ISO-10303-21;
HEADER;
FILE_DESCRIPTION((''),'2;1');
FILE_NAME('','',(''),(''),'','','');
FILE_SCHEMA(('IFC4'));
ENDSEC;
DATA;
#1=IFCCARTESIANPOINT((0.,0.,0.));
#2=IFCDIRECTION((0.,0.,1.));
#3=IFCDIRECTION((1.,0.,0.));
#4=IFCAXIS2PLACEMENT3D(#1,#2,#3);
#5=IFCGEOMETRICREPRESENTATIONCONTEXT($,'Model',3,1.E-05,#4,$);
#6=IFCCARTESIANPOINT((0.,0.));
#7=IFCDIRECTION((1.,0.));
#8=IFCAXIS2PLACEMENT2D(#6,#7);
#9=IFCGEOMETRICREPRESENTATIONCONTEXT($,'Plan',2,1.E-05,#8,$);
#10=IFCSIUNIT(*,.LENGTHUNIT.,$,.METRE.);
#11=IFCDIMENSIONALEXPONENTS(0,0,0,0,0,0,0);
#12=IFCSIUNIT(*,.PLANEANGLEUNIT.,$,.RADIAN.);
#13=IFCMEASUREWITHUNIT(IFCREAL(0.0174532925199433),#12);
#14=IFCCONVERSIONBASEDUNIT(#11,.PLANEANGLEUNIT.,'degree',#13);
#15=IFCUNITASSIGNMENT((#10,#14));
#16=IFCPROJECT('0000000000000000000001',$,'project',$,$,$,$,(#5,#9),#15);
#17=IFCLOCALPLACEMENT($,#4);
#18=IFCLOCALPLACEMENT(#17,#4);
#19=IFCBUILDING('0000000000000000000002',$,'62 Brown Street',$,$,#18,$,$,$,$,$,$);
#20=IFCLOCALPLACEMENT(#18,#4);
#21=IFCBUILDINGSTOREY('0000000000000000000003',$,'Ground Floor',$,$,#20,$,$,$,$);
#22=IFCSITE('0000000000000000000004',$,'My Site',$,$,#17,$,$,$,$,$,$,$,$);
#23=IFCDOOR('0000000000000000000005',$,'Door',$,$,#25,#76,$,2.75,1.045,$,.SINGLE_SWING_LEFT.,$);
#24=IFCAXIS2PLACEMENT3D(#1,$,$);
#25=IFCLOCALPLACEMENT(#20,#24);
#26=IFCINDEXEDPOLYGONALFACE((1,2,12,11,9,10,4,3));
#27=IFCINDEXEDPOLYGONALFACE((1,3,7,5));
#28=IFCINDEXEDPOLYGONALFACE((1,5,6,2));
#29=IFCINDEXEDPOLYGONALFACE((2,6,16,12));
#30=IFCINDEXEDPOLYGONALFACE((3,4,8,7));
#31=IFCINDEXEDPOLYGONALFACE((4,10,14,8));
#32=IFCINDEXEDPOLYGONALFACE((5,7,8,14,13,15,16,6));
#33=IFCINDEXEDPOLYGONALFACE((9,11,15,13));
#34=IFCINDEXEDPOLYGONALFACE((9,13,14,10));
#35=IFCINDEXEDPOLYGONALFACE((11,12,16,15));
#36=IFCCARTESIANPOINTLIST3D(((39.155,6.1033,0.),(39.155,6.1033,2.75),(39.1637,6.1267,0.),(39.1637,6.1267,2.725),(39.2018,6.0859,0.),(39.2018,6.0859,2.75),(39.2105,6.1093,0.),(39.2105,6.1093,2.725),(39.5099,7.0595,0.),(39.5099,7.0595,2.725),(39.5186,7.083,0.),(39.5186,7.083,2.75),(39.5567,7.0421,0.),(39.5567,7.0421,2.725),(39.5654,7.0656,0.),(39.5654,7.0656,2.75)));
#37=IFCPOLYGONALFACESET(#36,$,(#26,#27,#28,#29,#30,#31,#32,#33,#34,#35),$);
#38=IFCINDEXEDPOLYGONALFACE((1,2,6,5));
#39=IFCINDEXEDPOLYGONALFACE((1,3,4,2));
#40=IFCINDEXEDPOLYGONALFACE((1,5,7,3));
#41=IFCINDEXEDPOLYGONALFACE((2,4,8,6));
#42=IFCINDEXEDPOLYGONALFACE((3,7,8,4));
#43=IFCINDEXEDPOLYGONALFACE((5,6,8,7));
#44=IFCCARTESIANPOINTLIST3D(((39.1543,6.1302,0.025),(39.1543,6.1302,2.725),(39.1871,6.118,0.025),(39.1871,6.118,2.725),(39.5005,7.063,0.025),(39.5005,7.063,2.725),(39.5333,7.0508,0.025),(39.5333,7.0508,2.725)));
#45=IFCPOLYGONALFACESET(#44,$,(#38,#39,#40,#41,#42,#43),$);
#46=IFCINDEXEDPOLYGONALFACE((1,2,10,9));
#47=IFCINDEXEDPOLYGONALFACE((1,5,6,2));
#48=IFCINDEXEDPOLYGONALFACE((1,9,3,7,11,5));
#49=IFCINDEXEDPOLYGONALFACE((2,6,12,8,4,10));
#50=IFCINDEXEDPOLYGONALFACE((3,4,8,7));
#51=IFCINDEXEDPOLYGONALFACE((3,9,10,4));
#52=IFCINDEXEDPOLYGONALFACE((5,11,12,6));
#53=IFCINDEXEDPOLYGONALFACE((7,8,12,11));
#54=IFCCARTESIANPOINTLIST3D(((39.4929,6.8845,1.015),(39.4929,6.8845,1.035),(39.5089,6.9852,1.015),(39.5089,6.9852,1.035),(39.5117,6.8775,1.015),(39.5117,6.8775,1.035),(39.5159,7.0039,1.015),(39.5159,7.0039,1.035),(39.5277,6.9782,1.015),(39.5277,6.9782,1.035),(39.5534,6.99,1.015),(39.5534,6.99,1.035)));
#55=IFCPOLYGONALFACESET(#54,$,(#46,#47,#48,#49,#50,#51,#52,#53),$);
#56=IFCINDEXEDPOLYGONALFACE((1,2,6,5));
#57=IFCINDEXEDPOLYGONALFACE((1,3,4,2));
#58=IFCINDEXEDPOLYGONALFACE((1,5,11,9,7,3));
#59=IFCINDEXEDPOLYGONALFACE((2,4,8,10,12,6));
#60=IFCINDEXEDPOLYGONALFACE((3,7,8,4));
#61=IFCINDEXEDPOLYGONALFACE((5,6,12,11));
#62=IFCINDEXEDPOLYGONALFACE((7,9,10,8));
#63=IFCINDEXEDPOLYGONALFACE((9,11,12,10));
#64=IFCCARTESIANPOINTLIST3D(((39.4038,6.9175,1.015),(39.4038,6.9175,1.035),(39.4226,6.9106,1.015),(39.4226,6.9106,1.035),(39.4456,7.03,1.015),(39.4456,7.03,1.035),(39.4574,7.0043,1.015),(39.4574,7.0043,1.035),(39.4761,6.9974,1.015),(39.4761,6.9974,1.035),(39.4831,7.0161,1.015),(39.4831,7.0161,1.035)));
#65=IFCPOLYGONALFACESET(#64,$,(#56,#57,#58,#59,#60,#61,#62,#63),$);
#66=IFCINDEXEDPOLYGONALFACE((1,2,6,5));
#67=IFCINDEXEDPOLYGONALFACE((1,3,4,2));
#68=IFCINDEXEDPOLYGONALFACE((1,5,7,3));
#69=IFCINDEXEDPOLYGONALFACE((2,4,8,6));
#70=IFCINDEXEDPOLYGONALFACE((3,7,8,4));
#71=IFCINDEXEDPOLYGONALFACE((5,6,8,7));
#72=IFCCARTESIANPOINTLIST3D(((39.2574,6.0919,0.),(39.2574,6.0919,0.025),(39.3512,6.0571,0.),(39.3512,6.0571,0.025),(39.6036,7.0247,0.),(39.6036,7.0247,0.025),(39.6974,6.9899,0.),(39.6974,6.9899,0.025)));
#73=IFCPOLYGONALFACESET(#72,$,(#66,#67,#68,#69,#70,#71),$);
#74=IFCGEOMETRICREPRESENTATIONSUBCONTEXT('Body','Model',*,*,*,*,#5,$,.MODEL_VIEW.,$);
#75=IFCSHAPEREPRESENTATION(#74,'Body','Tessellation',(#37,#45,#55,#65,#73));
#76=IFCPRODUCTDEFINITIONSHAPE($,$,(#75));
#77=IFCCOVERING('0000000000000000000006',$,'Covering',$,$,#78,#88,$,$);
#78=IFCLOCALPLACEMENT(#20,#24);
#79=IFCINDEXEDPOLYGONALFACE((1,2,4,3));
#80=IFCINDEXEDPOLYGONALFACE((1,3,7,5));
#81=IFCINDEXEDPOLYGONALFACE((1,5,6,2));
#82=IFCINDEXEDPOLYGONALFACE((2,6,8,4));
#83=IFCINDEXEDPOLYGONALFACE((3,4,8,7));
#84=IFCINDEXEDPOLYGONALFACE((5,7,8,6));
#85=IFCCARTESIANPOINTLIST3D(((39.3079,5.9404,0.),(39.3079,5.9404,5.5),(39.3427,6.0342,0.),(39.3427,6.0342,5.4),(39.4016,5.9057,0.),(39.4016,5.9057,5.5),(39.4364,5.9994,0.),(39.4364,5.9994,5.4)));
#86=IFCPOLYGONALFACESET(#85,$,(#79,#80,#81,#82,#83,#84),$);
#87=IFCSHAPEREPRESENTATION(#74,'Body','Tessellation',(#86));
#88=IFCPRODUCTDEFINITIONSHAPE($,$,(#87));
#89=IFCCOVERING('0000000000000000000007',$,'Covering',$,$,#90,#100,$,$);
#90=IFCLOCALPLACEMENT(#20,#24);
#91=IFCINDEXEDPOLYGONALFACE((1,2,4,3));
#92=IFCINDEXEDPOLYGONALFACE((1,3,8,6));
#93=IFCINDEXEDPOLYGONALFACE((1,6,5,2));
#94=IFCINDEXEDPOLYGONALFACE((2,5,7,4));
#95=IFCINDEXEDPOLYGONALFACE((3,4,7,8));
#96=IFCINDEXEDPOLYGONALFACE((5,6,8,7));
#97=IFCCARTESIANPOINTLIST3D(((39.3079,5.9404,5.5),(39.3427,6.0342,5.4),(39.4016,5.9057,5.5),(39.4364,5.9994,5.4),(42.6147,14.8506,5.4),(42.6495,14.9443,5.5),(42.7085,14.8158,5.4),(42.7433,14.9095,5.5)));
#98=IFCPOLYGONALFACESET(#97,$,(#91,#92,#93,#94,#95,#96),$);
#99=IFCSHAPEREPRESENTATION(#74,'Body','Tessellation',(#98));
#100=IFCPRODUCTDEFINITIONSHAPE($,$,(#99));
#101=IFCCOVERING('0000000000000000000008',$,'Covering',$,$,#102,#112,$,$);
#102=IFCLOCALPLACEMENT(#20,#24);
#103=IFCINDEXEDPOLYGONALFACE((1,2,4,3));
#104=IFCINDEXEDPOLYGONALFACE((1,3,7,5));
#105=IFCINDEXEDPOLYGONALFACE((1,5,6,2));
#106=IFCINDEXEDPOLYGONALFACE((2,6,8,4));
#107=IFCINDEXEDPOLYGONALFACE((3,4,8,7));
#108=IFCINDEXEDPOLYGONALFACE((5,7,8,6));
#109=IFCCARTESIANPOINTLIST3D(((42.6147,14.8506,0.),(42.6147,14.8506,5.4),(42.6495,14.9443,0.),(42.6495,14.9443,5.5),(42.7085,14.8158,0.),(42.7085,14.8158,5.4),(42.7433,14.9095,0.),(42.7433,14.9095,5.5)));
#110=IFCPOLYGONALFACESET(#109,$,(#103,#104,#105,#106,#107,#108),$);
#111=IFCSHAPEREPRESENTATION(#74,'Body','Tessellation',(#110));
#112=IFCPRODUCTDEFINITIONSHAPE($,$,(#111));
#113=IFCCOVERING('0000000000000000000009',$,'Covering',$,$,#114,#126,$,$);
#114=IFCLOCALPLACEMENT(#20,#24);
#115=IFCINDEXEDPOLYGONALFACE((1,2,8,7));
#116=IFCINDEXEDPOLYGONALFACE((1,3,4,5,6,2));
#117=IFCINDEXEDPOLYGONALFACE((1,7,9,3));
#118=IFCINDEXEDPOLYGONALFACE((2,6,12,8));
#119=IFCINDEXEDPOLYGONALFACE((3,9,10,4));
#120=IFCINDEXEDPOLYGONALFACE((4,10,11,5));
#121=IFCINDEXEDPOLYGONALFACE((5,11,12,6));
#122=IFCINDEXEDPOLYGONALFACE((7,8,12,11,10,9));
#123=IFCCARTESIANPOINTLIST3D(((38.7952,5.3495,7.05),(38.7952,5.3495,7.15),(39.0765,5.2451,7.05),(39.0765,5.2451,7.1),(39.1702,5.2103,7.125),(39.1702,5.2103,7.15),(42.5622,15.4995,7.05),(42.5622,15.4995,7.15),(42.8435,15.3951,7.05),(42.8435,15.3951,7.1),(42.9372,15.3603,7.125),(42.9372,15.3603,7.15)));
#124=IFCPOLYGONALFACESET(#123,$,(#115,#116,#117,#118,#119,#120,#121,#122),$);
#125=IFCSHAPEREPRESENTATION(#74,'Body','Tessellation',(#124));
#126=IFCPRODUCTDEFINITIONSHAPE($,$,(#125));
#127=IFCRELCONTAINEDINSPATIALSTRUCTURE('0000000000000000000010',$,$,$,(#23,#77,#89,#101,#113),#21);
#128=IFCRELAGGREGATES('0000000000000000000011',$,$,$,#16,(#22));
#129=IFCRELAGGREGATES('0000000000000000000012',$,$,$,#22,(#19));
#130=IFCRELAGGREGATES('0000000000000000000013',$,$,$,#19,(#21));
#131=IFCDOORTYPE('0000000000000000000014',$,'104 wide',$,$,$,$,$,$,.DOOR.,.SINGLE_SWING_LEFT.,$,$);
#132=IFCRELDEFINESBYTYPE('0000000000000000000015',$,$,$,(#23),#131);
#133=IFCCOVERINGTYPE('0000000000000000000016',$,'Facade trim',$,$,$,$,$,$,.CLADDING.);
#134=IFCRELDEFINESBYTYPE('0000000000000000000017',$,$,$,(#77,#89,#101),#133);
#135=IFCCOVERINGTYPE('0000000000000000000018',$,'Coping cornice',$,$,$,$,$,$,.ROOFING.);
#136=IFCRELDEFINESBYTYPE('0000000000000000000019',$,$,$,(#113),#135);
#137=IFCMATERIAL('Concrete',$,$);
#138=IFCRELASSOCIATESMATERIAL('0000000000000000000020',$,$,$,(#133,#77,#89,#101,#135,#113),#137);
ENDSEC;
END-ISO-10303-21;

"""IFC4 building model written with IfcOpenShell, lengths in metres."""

from ifc_helpers import new_model, entity, si_unit, converted_unit, frame, origin_with_axes, origin_2d_with_axis, place, context, subcontext, project, spatial, line, indexed_curve, rectangle, outline, extrude, clip, halfspace, shape, source, transform, mapped, material, material_profile, profile_set, profile_usage, type_object, type_shapes, element, save


model = new_model("IFC4")

# Units and contexts
model_context = context("Model", 3, precision=1e-05, world=origin_with_axes())
plan_context = context("Plan", 2, precision=1e-05, world=origin_2d_with_axis())
body_context_1 = subcontext(model_context, "Body", "Model", "MODEL_VIEW")
body_context_2 = subcontext(plan_context, "Body", "Plan", "PLAN_VIEW")
ifc_project = project(units=[si_unit("LENGTHUNIT", "METRE"), converted_unit("PLANEANGLEUNIT", "degree", entity("IfcReal", 0.0174532925199433), si_unit("PLANEANGLEUNIT", "RADIAN"), dimensions=[0, 0, 0, 0, 0, 0, 0])], contexts=[model_context, plan_context])

# Site, building, storey
site_placement = place(None, origin_with_axes())
site = spatial("IfcSite", under=ifc_project, at=site_placement, Name="My Site")
building_placement = place(site_placement, origin_with_axes())
building = spatial("IfcBuilding", under=site, at=building_placement, Name="62 Brown Street")
storey_placement = place(building_placement, origin_with_axes())
storey = spatial("IfcBuildingStorey", under=building, at=storey_placement, Name="Ground Floor")

# Shared definitions
ifc_material_1 = material(Name="Concrete")

# Shared definitions
placement_1 = place(storey_placement, frame((39.024, 5.1755, 0.0), z_axis=(0.0, 0.0, 1.0), x_axis=(0.347944, 0.937515, 0.0)))

# Door
door_type_1 = type_object("IfcDoorType", Name="104 wide", OperationType="SINGLE_SWING_LEFT", PredefinedType="DOOR")
shared_shape_1 = source(origin_with_axes(), body_context_1, "Body", "SweptSolid", [
    extrude(outline(indexed_curve([(0.0, 0.0), (0.0, 2.75), (1.045, 2.75), (1.045, 0.0), (1.02, 0.0), (1.02, 2.725), (0.025, 2.725), (0.025, 0.0)], segments=[line(1, 2, 3, 4, 5, 6, 7, 8, 1)])), frame((0.0, 0.15, 0.0), z_axis=(0.0, -1.0, 0.0), x_axis=(1.0, 0.0, 0.0)), (0.0, 0.0, -1.0), 0.05),
    extrude(outline(indexed_curve([(0.0, 0.0), (0.995, 0.0), (0.995, 0.035), (0.0, 0.035)], segments=[line(1, 2, 3, 4, 1)])), frame((0.025, 0.175, 0.025), z_axis=(0.0, 0.0, 1.0), x_axis=(1.0, 0.0, 0.0)), (0.0, 0.0, 1.0), 2.7),
    extrude(outline(indexed_curve([(0.0, 0.0), (0.0, -0.04), (-0.12, -0.04), (-0.12, -0.02), (-0.02, -0.02), (-0.02, 0.0)], segments=[line(1, 2, 3, 4, 5, 6, 1)])), frame((0.97, 0.175, 1.015), z_axis=(0.0, 0.0, 1.0), x_axis=(1.0, 0.0, 0.0)), (0.0, 0.0, 1.0), 0.02),
    extrude(outline(indexed_curve([(0.0, 0.0), (0.0, 0.04), (-0.12, 0.04), (-0.12, 0.02), (-0.02, 0.02), (-0.02, 0.0)], segments=[line(1, 2, 3, 4, 5, 6, 1)])), frame((0.97, 0.21, 1.015), z_axis=(0.0, 0.0, 1.0), x_axis=(1.0, 0.0, 0.0)), (0.0, 0.0, 1.0), 0.02),
    extrude(outline(indexed_curve([(0.0, 0.0), (0.995, 0.0), (0.995, 0.1), (0.0, 0.1)], segments=[line(1, 2, 3, 4, 1)])), frame((0.025, 0.0, 0.0), z_axis=(0.0, 0.0, 1.0), x_axis=(1.0, 0.0, 0.0)), (0.0, 0.0, 1.0), 0.025),
])
shared_shape_2 = source(origin_with_axes(), body_context_2, "Body", "Curve2D", [
    entity("IfcIndexedPolyCurve", entity("IfcCartesianPointList2D", [[0.0, 0.15], [0.025, 0.15], [0.025, 0.2], [0.0, 0.2]]), [entity("IfcLineIndex", [1, 2, 3, 4, 1])]),
    entity("IfcIndexedPolyCurve", entity("IfcCartesianPointList2D", [[1.045, 0.15], [1.02, 0.15], [1.02, 0.2], [1.045, 0.2]]), [entity("IfcLineIndex", [1, 2, 3, 4, 1])]),
    entity("IfcTrimmedCurve", entity("IfcEllipse", entity("IfcAxis2Placement2D", entity("IfcCartesianPoint", [0.06, 0.2]), entity("IfcDirection", [1.0, 0.0])), 0.96, 0.995), [entity("IfcCartesianPoint", [1.02, 0.2])], [entity("IfcCartesianPoint", [0.06, 1.195])], True, "CARTESIAN"),
    entity("IfcIndexedPolyCurve", entity("IfcCartesianPointList2D", [[0.025, 0.2], [0.06, 0.2], [0.06, 1.195], [0.025, 1.195]]), [entity("IfcLineIndex", [1, 2, 3, 4, 1])]),
])
type_shapes(door_type_1, [shared_shape_1, shared_shape_2])
placement_2 = place(placement_1, frame((0.9154, 0.0, 0.0), z_axis=(0.0, 0.0, 1.0), x_axis=(1.0, 0.0, 0.0)))
door_1_placement = place(placement_2, frame((0.0, 0.0, 0.0), z_axis=(0.0, 0.0, 1.0), x_axis=(1.0, 0.0, 0.0)))
element("IfcDoor", 1, at=door_1_placement, inside=storey, type_object=door_type_1, Name="Door", OperationType="SINGLE_SWING_LEFT", OverallHeight=2.75, OverallWidth=1.045, shapes=[
    shape(body_context_1, "Body", "MappedRepresentation", [mapped(shared_shape_1, transform((0.0, 0.0, 0.0), x_axis=(1.0, 0.0, 0.0), y_axis=(0.0, 1.0, 0.0), z_axis=(0.0, 0.0, 1.0), scale=1.0))]),
    shape(body_context_2, "Body", "MappedRepresentation", [mapped(shared_shape_2, transform((0.0, 0.0, 0.0), x_axis=(1.0, 0.0, 0.0), y_axis=(0.0, 1.0, 0.0), z_axis=(0.0, 0.0, 1.0), scale=1.0))]),
])

# Coverings
ifc_material_profile_1 = material_profile(ifc_material_1, rectangle(XDim=0.1, YDim=0.1))
ifc_profile_set_1 = profile_set([ifc_material_profile_1], Name="cowl")
ifc_profile_usage_1 = profile_usage(ifc_profile_set_1, cardinal=5)
covering_type_1 = type_object("IfcCoveringType", Name="Facade trim", PredefinedType="CLADDING", material=ifc_profile_set_1)
covering_1_placement = place(storey_placement, frame((39.3721, 5.9699, 0.0), z_axis=(0.0, 0.0, 1.0), x_axis=(0.347944, 0.937515, 0.0)))
element("IfcCovering", 2, at=covering_1_placement, inside=storey, type_object=covering_type_1, material=ifc_profile_usage_1, Name="Covering", context=body_context_1, shape_type="Clipping", body=[
    clip(extrude(rectangle(XDim=0.1, YDim=0.1), origin_with_axes(), (0.0, 0.0, 1.0), 5.5), halfspace(frame((-0.05, 34.8348, 5.5), z_axis=(0.707098, 0.0, 0.707116), x_axis=(0.707116, 0.0, -0.707098)), False)),
])
ifc_profile_usage_2 = profile_usage(ifc_profile_set_1, cardinal=5)
covering_2_placement = place(storey_placement, frame((39.3547, 5.923, 5.45), z_axis=(0.347944, 0.937515, 0.0), x_axis=(0.0, 0.0, -1.0)))
element("IfcCovering", 3, at=covering_2_placement, inside=storey, type_object=covering_type_1, material=ifc_profile_usage_2, Name="Covering", context=body_context_1, shape_type="Clipping", body=[
    clip(clip(extrude(rectangle(XDim=0.1, YDim=0.1), origin_with_axes(), (0.0, 0.0, 1.0), 9.604), halfspace(frame((-0.05, 34.8348, 9.604), z_axis=(0.707114, 0.0, 0.7071), x_axis=(0.7071, -0.000003, -0.707113)), False)), halfspace(frame((-0.05, 34.8348, 0.0), z_axis=(0.707116, 0.0, -0.707098), x_axis=(0.707098, 0.0, 0.707116)), False)),
])
ifc_profile_usage_3 = profile_usage(ifc_profile_set_1, cardinal=5)
covering_3_placement = place(storey_placement, frame((42.679, 14.8801, 5.5), z_axis=(0.0, 0.0, -1.0), x_axis=(-0.347944, -0.937515, 0.0)))
element("IfcCovering", 4, at=covering_3_placement, inside=storey, type_object=covering_type_1, material=ifc_profile_usage_3, Name="Covering", context=body_context_1, shape_type="Clipping", body=[
    clip(extrude(rectangle(XDim=0.1, YDim=0.1), origin_with_axes(), (0.0, 0.0, 1.0), 5.5), halfspace(frame((-0.05, 34.8348, 0.0), z_axis=(0.7071, 0.0, -0.707113), x_axis=(0.707113, -0.000003, 0.7071)), False)),
])
ifc_material_profile_2 = material_profile(ifc_material_1, outline(indexed_curve([(-0.2, 0.1), (0.2, 0.1), (0.2, 0.075), (0.1, 0.05), (0.1, 0.0), (-0.2, 0.0)], segments=[line(5, 4), line(4, 3), line(3, 2), line(2, 1), line(1, 6), line(6, 5)], self_intersect=False)))
ifc_profile_set_2 = profile_set([ifc_material_profile_2], Name="cornice")
ifc_profile_usage_4 = profile_usage(ifc_profile_set_2, cardinal=5)
covering_type_2 = type_object("IfcCoveringType", Name="Coping cornice", PredefinedType="ROOFING", material=ifc_profile_set_2)
covering_4_placement = place(storey_placement, frame((42.7497, 15.4299, 7.05), z_axis=(-0.347944, -0.937515, 0.0), x_axis=(0.937515, -0.347944, 0.0)))
element("IfcCovering", 5, at=covering_4_placement, inside=storey, type_object=covering_type_2, material=ifc_profile_usage_4, Name="Covering", context=body_context_1, shape_type="SweptSolid", body=[
    extrude(outline(indexed_curve([(-0.2, 0.1), (0.2, 0.1), (0.2, 0.075), (0.1, 0.05), (0.1, 0.0), (-0.2, 0.0)], segments=[line(5, 4), line(4, 3), line(3, 2), line(2, 1), line(1, 6), line(6, 5)], self_intersect=False)), origin_with_axes(), (0.0, 0.0, 1.0), 10.8265),
])

save(model, "model.ifc")
